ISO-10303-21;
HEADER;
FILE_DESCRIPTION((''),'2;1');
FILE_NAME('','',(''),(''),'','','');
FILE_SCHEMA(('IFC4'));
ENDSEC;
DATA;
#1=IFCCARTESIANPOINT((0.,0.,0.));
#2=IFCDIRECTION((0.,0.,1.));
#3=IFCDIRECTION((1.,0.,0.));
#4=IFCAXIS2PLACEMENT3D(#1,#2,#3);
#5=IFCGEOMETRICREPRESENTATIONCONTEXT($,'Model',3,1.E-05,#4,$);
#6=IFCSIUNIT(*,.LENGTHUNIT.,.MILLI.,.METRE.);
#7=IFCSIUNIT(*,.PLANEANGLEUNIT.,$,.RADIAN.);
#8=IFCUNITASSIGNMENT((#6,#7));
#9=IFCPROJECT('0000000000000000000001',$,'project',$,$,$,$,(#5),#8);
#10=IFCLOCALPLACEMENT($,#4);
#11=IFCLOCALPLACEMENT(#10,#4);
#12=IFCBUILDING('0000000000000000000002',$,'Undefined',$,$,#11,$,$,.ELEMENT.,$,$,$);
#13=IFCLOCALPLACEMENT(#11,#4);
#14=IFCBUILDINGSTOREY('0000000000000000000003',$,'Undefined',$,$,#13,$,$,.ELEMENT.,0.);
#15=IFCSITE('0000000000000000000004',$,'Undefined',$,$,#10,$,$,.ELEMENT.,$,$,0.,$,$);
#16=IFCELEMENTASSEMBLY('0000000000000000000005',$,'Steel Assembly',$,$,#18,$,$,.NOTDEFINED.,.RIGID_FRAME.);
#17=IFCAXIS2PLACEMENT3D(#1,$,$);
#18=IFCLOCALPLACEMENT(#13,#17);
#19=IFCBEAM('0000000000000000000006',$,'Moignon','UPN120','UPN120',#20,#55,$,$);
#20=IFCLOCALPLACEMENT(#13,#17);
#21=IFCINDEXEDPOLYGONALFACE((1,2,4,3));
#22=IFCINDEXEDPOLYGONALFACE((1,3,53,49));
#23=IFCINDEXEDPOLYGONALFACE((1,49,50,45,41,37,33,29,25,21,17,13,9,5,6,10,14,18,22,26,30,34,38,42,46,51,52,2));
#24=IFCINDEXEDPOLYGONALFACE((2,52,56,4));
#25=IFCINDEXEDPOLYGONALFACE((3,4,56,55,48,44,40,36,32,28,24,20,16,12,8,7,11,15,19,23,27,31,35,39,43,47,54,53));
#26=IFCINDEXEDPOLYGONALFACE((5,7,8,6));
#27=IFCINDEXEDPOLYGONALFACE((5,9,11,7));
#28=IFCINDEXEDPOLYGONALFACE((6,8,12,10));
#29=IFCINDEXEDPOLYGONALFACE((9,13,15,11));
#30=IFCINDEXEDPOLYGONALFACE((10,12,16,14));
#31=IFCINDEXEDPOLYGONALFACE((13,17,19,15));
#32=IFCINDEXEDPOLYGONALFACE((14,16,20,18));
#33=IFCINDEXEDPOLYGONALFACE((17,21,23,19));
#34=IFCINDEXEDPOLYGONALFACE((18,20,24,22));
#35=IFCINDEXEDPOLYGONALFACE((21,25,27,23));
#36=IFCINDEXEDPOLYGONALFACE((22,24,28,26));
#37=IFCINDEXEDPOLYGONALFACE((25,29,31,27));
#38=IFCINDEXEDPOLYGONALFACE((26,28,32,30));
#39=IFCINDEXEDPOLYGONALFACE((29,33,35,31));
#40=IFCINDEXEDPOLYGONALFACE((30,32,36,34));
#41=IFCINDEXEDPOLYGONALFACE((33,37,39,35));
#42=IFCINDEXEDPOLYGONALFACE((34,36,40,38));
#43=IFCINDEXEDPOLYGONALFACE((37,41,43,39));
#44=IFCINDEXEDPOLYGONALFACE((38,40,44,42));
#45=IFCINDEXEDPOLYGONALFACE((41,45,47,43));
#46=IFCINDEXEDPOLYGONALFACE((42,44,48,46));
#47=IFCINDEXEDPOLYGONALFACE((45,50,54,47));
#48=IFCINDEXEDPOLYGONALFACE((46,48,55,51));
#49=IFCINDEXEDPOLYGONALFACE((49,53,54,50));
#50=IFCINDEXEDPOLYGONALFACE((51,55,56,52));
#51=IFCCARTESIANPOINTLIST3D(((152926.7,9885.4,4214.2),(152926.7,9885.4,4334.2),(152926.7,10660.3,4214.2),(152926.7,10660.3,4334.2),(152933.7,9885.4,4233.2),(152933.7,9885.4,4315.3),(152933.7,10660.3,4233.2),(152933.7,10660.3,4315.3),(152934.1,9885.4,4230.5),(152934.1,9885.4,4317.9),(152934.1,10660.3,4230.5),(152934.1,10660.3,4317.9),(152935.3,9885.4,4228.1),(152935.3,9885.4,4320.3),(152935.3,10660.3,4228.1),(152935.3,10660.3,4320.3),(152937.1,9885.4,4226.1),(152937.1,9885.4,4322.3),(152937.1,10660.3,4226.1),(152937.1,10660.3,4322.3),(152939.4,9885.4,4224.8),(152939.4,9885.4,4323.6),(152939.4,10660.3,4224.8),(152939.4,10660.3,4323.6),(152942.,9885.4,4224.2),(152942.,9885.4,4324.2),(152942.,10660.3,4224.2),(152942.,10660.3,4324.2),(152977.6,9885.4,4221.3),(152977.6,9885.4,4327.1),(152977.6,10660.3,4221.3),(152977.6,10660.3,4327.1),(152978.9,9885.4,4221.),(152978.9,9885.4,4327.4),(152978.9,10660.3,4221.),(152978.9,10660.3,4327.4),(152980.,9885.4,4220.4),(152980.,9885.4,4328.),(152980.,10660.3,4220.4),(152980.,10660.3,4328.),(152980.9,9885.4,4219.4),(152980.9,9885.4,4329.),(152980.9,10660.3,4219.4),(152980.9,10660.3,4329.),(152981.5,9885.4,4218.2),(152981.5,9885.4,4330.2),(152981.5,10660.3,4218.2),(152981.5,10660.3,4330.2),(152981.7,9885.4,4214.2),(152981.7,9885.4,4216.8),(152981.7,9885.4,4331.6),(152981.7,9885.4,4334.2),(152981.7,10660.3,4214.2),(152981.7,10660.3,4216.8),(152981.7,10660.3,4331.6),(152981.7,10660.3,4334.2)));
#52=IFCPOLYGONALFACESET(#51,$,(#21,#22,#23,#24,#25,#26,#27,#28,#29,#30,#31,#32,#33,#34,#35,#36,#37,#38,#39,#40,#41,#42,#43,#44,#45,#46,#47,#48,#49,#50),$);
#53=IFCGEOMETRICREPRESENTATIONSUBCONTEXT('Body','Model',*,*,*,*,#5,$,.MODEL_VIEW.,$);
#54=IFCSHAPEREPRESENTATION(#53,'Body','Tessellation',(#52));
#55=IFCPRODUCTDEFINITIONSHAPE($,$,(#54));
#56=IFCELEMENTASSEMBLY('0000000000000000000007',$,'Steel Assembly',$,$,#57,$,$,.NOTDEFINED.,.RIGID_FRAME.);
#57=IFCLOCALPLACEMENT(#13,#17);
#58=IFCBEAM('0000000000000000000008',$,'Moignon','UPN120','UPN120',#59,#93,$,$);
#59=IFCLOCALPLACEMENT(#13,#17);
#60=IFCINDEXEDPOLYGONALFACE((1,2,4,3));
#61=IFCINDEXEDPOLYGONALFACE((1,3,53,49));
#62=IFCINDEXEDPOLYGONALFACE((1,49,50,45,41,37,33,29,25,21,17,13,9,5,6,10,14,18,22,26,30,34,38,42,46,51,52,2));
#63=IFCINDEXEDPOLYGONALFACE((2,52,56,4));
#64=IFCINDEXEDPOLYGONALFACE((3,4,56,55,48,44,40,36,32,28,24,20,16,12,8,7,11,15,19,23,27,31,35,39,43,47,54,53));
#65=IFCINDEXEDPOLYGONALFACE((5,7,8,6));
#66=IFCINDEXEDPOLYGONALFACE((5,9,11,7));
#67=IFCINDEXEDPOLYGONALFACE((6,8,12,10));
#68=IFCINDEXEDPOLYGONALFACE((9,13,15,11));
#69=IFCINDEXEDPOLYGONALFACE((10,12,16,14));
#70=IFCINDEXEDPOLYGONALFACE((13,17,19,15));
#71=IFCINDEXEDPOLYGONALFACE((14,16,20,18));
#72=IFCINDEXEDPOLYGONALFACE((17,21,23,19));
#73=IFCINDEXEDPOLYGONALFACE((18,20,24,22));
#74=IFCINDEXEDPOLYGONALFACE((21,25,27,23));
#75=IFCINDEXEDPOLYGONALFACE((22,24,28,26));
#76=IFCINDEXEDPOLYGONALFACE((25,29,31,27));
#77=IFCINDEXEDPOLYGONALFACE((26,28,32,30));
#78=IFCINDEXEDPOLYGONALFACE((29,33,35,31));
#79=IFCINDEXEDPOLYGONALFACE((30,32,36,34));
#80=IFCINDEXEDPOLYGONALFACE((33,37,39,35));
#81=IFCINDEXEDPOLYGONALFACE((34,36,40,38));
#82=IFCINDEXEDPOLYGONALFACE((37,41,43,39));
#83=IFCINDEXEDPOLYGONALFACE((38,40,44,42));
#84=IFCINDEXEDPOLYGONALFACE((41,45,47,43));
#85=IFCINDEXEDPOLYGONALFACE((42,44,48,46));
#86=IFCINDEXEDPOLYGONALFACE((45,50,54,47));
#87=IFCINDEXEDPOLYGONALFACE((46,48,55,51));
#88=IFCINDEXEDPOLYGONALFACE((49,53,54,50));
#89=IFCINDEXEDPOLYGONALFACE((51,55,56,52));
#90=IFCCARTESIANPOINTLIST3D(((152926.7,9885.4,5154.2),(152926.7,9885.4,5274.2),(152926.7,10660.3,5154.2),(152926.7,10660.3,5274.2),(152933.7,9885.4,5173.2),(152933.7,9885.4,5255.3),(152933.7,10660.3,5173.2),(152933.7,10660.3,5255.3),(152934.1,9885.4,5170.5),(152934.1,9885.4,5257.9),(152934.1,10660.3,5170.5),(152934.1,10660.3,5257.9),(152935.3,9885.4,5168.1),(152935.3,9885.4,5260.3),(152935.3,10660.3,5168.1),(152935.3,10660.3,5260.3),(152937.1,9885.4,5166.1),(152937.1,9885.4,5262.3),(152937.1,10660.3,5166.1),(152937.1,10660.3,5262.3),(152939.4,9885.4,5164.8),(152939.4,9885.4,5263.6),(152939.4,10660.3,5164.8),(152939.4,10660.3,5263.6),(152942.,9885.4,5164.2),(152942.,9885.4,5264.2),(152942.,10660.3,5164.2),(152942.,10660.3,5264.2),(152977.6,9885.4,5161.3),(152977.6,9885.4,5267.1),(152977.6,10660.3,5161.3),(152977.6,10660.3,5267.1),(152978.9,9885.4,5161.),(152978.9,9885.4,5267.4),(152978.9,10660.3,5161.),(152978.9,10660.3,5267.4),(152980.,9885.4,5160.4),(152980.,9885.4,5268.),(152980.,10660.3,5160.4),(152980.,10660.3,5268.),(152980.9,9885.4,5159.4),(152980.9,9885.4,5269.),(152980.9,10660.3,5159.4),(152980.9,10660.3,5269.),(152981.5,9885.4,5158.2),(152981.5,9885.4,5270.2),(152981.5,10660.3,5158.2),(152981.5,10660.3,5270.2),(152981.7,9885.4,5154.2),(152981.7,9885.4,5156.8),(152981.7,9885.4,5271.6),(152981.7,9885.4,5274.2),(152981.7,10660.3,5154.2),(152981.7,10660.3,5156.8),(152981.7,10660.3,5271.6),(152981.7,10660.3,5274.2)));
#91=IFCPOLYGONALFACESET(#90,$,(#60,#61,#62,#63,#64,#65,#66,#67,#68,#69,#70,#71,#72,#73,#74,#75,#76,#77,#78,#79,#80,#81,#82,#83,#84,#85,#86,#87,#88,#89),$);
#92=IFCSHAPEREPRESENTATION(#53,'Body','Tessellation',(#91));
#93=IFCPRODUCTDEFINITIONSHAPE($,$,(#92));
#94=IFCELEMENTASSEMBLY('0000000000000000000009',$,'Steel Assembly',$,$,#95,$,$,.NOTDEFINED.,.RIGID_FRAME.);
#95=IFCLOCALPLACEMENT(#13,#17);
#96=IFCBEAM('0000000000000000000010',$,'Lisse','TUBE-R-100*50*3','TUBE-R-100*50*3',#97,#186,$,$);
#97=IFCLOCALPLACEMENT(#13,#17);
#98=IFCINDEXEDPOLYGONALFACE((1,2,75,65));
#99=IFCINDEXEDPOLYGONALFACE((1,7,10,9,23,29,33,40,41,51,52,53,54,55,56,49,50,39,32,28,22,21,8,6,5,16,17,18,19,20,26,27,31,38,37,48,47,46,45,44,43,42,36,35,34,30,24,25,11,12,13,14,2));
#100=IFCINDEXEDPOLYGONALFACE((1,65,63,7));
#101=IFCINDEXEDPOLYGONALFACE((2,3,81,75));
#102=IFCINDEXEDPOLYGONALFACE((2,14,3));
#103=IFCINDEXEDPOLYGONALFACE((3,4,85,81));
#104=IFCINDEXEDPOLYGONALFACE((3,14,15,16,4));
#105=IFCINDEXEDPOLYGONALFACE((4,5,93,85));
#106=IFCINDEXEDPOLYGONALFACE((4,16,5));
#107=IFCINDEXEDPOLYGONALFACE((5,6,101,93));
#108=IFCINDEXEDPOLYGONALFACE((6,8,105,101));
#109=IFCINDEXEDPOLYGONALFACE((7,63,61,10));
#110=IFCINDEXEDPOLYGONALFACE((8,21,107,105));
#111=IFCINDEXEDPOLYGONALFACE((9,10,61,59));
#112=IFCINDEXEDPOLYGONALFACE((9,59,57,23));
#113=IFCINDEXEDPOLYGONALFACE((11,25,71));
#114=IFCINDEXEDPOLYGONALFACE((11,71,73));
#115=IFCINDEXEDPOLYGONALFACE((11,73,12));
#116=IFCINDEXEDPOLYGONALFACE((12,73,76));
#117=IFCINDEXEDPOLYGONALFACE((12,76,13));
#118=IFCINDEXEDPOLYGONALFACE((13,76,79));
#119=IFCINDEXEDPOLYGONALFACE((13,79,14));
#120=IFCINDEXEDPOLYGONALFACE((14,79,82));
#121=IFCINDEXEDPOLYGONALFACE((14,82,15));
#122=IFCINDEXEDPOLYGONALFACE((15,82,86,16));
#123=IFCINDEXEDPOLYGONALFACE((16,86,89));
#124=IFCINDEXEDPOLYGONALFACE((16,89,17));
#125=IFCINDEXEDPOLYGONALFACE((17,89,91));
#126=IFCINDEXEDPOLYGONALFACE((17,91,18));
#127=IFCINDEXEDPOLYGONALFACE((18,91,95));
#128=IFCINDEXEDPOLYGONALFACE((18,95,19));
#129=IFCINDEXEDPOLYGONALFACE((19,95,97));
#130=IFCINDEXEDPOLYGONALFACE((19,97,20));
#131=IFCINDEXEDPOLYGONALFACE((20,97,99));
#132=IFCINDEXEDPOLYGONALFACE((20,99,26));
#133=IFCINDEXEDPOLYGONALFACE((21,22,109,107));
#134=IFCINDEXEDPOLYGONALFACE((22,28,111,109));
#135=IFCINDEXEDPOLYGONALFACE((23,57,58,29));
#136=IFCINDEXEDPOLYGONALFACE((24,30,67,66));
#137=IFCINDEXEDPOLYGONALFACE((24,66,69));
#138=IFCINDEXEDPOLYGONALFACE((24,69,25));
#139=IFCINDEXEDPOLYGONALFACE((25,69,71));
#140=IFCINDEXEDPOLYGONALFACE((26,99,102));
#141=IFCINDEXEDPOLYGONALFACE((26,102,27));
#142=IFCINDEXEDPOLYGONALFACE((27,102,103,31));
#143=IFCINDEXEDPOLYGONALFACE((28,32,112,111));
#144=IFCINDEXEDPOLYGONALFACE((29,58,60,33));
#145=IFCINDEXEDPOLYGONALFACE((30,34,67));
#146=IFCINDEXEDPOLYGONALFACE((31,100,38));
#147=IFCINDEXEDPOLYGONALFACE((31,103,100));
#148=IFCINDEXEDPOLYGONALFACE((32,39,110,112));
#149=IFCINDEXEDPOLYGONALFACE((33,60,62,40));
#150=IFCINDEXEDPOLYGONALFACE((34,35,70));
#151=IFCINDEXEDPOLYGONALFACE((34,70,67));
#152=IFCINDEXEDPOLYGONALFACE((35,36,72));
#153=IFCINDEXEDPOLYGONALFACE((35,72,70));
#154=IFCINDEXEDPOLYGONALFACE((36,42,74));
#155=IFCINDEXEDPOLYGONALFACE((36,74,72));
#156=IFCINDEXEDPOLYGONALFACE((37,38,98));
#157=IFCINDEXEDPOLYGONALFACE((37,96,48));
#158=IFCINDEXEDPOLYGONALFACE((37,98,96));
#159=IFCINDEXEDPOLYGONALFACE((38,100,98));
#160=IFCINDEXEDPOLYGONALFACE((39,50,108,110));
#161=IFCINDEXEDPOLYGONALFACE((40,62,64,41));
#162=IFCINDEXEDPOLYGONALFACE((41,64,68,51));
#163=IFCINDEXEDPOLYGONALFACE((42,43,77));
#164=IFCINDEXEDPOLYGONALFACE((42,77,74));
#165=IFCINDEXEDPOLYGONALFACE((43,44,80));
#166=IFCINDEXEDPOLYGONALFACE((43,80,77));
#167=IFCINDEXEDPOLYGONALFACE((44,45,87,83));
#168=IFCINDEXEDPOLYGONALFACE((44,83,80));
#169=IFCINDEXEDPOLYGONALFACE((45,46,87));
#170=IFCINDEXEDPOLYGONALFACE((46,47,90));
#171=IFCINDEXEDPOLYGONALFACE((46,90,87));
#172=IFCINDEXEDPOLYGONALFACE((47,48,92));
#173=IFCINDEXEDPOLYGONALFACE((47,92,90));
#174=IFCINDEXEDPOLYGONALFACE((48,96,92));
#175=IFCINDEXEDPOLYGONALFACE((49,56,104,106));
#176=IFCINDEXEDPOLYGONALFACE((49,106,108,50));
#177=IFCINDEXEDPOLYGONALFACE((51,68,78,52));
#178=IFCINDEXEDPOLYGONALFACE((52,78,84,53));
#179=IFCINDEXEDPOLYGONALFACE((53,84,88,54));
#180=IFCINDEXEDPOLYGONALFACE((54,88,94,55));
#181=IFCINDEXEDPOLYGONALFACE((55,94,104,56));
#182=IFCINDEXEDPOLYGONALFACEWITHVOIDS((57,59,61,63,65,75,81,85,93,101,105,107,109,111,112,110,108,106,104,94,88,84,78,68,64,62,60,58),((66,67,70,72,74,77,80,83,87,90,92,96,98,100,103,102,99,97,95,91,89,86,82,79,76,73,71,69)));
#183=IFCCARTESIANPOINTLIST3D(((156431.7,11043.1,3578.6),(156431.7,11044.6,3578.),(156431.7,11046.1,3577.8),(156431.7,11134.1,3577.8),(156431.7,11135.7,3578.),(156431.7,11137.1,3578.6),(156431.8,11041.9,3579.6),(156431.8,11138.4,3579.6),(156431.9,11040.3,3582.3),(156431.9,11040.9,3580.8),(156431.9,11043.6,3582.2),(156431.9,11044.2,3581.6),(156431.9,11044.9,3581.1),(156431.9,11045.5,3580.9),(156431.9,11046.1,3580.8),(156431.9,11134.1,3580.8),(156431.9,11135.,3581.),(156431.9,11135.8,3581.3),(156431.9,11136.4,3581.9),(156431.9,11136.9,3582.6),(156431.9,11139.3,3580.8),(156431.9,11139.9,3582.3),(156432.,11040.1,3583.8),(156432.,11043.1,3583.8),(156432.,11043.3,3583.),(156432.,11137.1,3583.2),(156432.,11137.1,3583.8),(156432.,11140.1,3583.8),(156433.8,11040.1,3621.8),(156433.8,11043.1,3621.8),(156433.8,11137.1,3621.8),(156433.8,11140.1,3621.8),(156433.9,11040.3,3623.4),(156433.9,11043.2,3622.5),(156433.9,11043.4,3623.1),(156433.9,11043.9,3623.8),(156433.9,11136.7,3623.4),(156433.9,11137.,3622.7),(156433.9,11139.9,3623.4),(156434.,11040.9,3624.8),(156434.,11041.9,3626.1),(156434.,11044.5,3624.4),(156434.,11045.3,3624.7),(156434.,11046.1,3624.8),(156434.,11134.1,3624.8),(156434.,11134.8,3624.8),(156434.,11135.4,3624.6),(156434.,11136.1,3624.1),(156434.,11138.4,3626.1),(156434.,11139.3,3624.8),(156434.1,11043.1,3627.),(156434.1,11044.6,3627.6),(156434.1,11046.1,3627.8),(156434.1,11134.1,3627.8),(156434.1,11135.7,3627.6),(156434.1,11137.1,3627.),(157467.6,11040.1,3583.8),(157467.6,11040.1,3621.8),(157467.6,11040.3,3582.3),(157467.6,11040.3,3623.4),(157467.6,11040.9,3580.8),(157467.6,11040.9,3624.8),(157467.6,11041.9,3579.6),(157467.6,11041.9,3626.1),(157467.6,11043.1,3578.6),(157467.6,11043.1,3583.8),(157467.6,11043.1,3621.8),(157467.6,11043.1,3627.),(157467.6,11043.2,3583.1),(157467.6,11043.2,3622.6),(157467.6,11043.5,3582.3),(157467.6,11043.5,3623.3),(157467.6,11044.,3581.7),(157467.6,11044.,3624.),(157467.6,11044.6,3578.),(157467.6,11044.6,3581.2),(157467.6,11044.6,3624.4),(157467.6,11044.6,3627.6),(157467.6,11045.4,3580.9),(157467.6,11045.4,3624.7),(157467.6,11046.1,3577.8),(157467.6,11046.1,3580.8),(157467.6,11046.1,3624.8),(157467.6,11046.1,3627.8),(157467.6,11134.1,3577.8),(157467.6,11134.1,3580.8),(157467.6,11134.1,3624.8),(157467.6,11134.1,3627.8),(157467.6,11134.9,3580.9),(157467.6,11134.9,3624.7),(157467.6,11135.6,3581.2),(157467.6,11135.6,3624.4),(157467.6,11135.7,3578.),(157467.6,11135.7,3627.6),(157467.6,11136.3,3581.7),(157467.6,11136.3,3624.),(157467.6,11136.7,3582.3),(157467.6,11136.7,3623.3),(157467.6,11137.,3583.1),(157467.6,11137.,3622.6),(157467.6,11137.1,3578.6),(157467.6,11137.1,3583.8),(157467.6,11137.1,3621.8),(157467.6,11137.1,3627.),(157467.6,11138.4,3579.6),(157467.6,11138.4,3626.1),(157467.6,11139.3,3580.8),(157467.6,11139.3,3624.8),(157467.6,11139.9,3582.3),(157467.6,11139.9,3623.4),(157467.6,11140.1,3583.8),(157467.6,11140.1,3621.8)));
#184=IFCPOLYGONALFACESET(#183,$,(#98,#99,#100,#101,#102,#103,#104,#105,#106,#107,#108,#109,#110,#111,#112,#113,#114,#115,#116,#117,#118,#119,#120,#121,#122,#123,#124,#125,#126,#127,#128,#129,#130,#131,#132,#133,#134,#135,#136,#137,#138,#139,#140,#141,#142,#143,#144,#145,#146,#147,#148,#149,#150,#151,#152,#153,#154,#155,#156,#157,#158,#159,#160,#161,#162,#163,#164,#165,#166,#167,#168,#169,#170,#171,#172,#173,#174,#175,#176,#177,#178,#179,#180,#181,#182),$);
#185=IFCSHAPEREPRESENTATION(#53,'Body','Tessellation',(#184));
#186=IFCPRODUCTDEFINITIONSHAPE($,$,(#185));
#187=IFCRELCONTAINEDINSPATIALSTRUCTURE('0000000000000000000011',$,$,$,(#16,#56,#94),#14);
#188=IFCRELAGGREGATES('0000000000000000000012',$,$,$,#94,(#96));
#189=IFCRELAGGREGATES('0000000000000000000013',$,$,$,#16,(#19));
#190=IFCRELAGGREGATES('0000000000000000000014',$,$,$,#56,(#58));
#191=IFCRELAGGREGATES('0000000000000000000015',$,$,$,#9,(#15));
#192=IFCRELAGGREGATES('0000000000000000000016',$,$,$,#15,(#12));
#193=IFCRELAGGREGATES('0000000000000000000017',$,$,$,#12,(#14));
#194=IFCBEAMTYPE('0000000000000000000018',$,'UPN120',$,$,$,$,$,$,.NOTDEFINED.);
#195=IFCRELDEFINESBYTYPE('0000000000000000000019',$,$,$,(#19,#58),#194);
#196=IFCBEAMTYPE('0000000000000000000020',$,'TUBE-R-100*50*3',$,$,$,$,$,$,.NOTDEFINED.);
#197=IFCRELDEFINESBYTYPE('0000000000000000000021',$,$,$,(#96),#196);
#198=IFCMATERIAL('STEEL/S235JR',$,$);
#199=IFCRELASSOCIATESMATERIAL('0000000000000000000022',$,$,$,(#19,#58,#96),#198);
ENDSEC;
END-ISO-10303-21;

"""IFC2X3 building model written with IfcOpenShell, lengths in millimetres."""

from ifc_helpers import new_model, si_unit, frame, origin_with_axes, origin_2d_with_axis, place, context, subcontext, project, spatial, hollow_rectangle, u_section, extrude, clip, halfspace, material, type_object, element, aggregate, save


model = new_model("IFC2X3")

# Units and contexts
model_context = context("Model", 3, precision=1e-05, world=origin_with_axes())
body_context = subcontext(model_context, "Body", "Model", "MODEL_VIEW")
ifc_project = project(units=[si_unit("LENGTHUNIT", "METRE", prefix="MILLI"), si_unit("PLANEANGLEUNIT", "RADIAN")], contexts=[model_context])

# Site, building, storey
site_placement = place(None, origin_with_axes())
site = spatial("IfcSite", under=ifc_project, at=site_placement, Name="Undefined", CompositionType="ELEMENT", RefElevation=0.0)
building_placement = place(site_placement, origin_with_axes())
building = spatial("IfcBuilding", under=site, at=building_placement, Name="Undefined", CompositionType="ELEMENT")
storey_placement = place(building_placement, origin_with_axes())
storey = spatial("IfcBuildingStorey", under=building, at=storey_placement, Name="Undefined", CompositionType="ELEMENT", Elevation=0.0)

# Element assemblies, beams
assembly_1_placement = place(storey_placement, origin_with_axes())
assembly_1 = element("IfcElementAssembly", 1, at=assembly_1_placement, inside=storey, Name="Steel Assembly", AssemblyPlace="NOTDEFINED", PredefinedType="RIGID_FRAME")
ifc_material_1 = material(Name="STEEL/S235JR")
beam_type_1 = type_object("IfcBeamType", Name="UPN120", PredefinedType="NOTDEFINED")
beam_1_placement = place(assembly_1_placement, frame((152954.2, 10660.3, 4274.2), z_axis=(0.0, 0.0, -1.0), x_axis=(0.0, -1.0, 0.0)))
beam_1 = element("IfcBeam", 2, at=beam_1_placement, type_object=beam_type_1, material=ifc_material_1, Name="Moignon", Description="UPN120", ObjectType="UPN120", context=body_context, shape_type="SweptSolid", body=[
    extrude(u_section(Depth=120.0, FlangeWidth=55.0, WebThickness=7.0, FlangeThickness=9.0, FilletRadius=9.0, EdgeRadius=4.5, FlangeSlope=0.07983, at=origin_2d_with_axis()), frame((774.9, 0.0, 0.0), z_axis=(-1.0, 0.0, 0.0), x_axis=(0.0, -1.0, 0.0)), (0.0, 0.0, 1.0), 774.9),
])
assembly_2_placement = place(storey_placement, origin_with_axes())
assembly_2 = element("IfcElementAssembly", 3, at=assembly_2_placement, inside=storey, Name="Steel Assembly", AssemblyPlace="NOTDEFINED", PredefinedType="RIGID_FRAME")
beam_2_placement = place(assembly_2_placement, frame((152954.2, 10660.3, 5214.2), z_axis=(0.0, 0.0, -1.0), x_axis=(0.0, -1.0, 0.0)))
beam_2 = element("IfcBeam", 4, at=beam_2_placement, type_object=beam_type_1, material=ifc_material_1, Name="Moignon", Description="UPN120", ObjectType="UPN120", context=body_context, shape_type="SweptSolid", body=[
    extrude(u_section(Depth=120.0, FlangeWidth=55.0, WebThickness=7.0, FlangeThickness=9.0, FilletRadius=9.0, EdgeRadius=4.5, FlangeSlope=0.07983, at=origin_2d_with_axis()), frame((774.9, 0.0, 0.0), z_axis=(-1.0, 0.0, 0.0), x_axis=(0.0, -1.0, 0.0)), (0.0, 0.0, 1.0), 774.9),
])
assembly_3_placement = place(storey_placement, origin_with_axes())
assembly_3 = element("IfcElementAssembly", 5, at=assembly_3_placement, inside=storey, Name="Steel Assembly", AssemblyPlace="NOTDEFINED", PredefinedType="RIGID_FRAME")
beam_type_2 = type_object("IfcBeamType", Name="TUBE-R-100*50*3", PredefinedType="NOTDEFINED")
beam_3_placement = place(assembly_3_placement, frame((157467.6, 11090.1, 3602.8), z_axis=(0.0, 1.0, 0.0), x_axis=(-1.0, 0.0, 0.0)))
beam_3 = element("IfcBeam", 6, at=beam_3_placement, type_object=beam_type_2, material=ifc_material_1, Name="Lisse", Description="TUBE-R-100*50*3", ObjectType="TUBE-R-100*50*3", context=body_context, shape_type="Clipping", body=[
    clip(clip(extrude(hollow_rectangle(XDim=50.0, YDim=100.0, WallThickness=3.0, InnerFilletRadius=3.0, OuterFilletRadius=6.0, at=origin_2d_with_axis()), frame((1035.9, 0.0, 0.0), z_axis=(-1.0, 0.0, 0.0), x_axis=(0.0, -1.0, 0.0)), (0.0, 0.0, 1.0), 1035.9), halfspace(frame((0.0, 25.0, -75.0), z_axis=(-1.0, 0.000001, 0.0), x_axis=(0.0, 0.0, 1.0)), False)), halfspace(frame((1037.2, -52.2, -959.8), z_axis=(-0.998827, -0.04842, 0.0), x_axis=(0.0, 0.0, -1.0)), True)),
])
aggregate(assembly_3, [beam_3])

aggregate(assembly_1, [beam_1])
aggregate(assembly_2, [beam_2])

save(model, "model.ifc")
